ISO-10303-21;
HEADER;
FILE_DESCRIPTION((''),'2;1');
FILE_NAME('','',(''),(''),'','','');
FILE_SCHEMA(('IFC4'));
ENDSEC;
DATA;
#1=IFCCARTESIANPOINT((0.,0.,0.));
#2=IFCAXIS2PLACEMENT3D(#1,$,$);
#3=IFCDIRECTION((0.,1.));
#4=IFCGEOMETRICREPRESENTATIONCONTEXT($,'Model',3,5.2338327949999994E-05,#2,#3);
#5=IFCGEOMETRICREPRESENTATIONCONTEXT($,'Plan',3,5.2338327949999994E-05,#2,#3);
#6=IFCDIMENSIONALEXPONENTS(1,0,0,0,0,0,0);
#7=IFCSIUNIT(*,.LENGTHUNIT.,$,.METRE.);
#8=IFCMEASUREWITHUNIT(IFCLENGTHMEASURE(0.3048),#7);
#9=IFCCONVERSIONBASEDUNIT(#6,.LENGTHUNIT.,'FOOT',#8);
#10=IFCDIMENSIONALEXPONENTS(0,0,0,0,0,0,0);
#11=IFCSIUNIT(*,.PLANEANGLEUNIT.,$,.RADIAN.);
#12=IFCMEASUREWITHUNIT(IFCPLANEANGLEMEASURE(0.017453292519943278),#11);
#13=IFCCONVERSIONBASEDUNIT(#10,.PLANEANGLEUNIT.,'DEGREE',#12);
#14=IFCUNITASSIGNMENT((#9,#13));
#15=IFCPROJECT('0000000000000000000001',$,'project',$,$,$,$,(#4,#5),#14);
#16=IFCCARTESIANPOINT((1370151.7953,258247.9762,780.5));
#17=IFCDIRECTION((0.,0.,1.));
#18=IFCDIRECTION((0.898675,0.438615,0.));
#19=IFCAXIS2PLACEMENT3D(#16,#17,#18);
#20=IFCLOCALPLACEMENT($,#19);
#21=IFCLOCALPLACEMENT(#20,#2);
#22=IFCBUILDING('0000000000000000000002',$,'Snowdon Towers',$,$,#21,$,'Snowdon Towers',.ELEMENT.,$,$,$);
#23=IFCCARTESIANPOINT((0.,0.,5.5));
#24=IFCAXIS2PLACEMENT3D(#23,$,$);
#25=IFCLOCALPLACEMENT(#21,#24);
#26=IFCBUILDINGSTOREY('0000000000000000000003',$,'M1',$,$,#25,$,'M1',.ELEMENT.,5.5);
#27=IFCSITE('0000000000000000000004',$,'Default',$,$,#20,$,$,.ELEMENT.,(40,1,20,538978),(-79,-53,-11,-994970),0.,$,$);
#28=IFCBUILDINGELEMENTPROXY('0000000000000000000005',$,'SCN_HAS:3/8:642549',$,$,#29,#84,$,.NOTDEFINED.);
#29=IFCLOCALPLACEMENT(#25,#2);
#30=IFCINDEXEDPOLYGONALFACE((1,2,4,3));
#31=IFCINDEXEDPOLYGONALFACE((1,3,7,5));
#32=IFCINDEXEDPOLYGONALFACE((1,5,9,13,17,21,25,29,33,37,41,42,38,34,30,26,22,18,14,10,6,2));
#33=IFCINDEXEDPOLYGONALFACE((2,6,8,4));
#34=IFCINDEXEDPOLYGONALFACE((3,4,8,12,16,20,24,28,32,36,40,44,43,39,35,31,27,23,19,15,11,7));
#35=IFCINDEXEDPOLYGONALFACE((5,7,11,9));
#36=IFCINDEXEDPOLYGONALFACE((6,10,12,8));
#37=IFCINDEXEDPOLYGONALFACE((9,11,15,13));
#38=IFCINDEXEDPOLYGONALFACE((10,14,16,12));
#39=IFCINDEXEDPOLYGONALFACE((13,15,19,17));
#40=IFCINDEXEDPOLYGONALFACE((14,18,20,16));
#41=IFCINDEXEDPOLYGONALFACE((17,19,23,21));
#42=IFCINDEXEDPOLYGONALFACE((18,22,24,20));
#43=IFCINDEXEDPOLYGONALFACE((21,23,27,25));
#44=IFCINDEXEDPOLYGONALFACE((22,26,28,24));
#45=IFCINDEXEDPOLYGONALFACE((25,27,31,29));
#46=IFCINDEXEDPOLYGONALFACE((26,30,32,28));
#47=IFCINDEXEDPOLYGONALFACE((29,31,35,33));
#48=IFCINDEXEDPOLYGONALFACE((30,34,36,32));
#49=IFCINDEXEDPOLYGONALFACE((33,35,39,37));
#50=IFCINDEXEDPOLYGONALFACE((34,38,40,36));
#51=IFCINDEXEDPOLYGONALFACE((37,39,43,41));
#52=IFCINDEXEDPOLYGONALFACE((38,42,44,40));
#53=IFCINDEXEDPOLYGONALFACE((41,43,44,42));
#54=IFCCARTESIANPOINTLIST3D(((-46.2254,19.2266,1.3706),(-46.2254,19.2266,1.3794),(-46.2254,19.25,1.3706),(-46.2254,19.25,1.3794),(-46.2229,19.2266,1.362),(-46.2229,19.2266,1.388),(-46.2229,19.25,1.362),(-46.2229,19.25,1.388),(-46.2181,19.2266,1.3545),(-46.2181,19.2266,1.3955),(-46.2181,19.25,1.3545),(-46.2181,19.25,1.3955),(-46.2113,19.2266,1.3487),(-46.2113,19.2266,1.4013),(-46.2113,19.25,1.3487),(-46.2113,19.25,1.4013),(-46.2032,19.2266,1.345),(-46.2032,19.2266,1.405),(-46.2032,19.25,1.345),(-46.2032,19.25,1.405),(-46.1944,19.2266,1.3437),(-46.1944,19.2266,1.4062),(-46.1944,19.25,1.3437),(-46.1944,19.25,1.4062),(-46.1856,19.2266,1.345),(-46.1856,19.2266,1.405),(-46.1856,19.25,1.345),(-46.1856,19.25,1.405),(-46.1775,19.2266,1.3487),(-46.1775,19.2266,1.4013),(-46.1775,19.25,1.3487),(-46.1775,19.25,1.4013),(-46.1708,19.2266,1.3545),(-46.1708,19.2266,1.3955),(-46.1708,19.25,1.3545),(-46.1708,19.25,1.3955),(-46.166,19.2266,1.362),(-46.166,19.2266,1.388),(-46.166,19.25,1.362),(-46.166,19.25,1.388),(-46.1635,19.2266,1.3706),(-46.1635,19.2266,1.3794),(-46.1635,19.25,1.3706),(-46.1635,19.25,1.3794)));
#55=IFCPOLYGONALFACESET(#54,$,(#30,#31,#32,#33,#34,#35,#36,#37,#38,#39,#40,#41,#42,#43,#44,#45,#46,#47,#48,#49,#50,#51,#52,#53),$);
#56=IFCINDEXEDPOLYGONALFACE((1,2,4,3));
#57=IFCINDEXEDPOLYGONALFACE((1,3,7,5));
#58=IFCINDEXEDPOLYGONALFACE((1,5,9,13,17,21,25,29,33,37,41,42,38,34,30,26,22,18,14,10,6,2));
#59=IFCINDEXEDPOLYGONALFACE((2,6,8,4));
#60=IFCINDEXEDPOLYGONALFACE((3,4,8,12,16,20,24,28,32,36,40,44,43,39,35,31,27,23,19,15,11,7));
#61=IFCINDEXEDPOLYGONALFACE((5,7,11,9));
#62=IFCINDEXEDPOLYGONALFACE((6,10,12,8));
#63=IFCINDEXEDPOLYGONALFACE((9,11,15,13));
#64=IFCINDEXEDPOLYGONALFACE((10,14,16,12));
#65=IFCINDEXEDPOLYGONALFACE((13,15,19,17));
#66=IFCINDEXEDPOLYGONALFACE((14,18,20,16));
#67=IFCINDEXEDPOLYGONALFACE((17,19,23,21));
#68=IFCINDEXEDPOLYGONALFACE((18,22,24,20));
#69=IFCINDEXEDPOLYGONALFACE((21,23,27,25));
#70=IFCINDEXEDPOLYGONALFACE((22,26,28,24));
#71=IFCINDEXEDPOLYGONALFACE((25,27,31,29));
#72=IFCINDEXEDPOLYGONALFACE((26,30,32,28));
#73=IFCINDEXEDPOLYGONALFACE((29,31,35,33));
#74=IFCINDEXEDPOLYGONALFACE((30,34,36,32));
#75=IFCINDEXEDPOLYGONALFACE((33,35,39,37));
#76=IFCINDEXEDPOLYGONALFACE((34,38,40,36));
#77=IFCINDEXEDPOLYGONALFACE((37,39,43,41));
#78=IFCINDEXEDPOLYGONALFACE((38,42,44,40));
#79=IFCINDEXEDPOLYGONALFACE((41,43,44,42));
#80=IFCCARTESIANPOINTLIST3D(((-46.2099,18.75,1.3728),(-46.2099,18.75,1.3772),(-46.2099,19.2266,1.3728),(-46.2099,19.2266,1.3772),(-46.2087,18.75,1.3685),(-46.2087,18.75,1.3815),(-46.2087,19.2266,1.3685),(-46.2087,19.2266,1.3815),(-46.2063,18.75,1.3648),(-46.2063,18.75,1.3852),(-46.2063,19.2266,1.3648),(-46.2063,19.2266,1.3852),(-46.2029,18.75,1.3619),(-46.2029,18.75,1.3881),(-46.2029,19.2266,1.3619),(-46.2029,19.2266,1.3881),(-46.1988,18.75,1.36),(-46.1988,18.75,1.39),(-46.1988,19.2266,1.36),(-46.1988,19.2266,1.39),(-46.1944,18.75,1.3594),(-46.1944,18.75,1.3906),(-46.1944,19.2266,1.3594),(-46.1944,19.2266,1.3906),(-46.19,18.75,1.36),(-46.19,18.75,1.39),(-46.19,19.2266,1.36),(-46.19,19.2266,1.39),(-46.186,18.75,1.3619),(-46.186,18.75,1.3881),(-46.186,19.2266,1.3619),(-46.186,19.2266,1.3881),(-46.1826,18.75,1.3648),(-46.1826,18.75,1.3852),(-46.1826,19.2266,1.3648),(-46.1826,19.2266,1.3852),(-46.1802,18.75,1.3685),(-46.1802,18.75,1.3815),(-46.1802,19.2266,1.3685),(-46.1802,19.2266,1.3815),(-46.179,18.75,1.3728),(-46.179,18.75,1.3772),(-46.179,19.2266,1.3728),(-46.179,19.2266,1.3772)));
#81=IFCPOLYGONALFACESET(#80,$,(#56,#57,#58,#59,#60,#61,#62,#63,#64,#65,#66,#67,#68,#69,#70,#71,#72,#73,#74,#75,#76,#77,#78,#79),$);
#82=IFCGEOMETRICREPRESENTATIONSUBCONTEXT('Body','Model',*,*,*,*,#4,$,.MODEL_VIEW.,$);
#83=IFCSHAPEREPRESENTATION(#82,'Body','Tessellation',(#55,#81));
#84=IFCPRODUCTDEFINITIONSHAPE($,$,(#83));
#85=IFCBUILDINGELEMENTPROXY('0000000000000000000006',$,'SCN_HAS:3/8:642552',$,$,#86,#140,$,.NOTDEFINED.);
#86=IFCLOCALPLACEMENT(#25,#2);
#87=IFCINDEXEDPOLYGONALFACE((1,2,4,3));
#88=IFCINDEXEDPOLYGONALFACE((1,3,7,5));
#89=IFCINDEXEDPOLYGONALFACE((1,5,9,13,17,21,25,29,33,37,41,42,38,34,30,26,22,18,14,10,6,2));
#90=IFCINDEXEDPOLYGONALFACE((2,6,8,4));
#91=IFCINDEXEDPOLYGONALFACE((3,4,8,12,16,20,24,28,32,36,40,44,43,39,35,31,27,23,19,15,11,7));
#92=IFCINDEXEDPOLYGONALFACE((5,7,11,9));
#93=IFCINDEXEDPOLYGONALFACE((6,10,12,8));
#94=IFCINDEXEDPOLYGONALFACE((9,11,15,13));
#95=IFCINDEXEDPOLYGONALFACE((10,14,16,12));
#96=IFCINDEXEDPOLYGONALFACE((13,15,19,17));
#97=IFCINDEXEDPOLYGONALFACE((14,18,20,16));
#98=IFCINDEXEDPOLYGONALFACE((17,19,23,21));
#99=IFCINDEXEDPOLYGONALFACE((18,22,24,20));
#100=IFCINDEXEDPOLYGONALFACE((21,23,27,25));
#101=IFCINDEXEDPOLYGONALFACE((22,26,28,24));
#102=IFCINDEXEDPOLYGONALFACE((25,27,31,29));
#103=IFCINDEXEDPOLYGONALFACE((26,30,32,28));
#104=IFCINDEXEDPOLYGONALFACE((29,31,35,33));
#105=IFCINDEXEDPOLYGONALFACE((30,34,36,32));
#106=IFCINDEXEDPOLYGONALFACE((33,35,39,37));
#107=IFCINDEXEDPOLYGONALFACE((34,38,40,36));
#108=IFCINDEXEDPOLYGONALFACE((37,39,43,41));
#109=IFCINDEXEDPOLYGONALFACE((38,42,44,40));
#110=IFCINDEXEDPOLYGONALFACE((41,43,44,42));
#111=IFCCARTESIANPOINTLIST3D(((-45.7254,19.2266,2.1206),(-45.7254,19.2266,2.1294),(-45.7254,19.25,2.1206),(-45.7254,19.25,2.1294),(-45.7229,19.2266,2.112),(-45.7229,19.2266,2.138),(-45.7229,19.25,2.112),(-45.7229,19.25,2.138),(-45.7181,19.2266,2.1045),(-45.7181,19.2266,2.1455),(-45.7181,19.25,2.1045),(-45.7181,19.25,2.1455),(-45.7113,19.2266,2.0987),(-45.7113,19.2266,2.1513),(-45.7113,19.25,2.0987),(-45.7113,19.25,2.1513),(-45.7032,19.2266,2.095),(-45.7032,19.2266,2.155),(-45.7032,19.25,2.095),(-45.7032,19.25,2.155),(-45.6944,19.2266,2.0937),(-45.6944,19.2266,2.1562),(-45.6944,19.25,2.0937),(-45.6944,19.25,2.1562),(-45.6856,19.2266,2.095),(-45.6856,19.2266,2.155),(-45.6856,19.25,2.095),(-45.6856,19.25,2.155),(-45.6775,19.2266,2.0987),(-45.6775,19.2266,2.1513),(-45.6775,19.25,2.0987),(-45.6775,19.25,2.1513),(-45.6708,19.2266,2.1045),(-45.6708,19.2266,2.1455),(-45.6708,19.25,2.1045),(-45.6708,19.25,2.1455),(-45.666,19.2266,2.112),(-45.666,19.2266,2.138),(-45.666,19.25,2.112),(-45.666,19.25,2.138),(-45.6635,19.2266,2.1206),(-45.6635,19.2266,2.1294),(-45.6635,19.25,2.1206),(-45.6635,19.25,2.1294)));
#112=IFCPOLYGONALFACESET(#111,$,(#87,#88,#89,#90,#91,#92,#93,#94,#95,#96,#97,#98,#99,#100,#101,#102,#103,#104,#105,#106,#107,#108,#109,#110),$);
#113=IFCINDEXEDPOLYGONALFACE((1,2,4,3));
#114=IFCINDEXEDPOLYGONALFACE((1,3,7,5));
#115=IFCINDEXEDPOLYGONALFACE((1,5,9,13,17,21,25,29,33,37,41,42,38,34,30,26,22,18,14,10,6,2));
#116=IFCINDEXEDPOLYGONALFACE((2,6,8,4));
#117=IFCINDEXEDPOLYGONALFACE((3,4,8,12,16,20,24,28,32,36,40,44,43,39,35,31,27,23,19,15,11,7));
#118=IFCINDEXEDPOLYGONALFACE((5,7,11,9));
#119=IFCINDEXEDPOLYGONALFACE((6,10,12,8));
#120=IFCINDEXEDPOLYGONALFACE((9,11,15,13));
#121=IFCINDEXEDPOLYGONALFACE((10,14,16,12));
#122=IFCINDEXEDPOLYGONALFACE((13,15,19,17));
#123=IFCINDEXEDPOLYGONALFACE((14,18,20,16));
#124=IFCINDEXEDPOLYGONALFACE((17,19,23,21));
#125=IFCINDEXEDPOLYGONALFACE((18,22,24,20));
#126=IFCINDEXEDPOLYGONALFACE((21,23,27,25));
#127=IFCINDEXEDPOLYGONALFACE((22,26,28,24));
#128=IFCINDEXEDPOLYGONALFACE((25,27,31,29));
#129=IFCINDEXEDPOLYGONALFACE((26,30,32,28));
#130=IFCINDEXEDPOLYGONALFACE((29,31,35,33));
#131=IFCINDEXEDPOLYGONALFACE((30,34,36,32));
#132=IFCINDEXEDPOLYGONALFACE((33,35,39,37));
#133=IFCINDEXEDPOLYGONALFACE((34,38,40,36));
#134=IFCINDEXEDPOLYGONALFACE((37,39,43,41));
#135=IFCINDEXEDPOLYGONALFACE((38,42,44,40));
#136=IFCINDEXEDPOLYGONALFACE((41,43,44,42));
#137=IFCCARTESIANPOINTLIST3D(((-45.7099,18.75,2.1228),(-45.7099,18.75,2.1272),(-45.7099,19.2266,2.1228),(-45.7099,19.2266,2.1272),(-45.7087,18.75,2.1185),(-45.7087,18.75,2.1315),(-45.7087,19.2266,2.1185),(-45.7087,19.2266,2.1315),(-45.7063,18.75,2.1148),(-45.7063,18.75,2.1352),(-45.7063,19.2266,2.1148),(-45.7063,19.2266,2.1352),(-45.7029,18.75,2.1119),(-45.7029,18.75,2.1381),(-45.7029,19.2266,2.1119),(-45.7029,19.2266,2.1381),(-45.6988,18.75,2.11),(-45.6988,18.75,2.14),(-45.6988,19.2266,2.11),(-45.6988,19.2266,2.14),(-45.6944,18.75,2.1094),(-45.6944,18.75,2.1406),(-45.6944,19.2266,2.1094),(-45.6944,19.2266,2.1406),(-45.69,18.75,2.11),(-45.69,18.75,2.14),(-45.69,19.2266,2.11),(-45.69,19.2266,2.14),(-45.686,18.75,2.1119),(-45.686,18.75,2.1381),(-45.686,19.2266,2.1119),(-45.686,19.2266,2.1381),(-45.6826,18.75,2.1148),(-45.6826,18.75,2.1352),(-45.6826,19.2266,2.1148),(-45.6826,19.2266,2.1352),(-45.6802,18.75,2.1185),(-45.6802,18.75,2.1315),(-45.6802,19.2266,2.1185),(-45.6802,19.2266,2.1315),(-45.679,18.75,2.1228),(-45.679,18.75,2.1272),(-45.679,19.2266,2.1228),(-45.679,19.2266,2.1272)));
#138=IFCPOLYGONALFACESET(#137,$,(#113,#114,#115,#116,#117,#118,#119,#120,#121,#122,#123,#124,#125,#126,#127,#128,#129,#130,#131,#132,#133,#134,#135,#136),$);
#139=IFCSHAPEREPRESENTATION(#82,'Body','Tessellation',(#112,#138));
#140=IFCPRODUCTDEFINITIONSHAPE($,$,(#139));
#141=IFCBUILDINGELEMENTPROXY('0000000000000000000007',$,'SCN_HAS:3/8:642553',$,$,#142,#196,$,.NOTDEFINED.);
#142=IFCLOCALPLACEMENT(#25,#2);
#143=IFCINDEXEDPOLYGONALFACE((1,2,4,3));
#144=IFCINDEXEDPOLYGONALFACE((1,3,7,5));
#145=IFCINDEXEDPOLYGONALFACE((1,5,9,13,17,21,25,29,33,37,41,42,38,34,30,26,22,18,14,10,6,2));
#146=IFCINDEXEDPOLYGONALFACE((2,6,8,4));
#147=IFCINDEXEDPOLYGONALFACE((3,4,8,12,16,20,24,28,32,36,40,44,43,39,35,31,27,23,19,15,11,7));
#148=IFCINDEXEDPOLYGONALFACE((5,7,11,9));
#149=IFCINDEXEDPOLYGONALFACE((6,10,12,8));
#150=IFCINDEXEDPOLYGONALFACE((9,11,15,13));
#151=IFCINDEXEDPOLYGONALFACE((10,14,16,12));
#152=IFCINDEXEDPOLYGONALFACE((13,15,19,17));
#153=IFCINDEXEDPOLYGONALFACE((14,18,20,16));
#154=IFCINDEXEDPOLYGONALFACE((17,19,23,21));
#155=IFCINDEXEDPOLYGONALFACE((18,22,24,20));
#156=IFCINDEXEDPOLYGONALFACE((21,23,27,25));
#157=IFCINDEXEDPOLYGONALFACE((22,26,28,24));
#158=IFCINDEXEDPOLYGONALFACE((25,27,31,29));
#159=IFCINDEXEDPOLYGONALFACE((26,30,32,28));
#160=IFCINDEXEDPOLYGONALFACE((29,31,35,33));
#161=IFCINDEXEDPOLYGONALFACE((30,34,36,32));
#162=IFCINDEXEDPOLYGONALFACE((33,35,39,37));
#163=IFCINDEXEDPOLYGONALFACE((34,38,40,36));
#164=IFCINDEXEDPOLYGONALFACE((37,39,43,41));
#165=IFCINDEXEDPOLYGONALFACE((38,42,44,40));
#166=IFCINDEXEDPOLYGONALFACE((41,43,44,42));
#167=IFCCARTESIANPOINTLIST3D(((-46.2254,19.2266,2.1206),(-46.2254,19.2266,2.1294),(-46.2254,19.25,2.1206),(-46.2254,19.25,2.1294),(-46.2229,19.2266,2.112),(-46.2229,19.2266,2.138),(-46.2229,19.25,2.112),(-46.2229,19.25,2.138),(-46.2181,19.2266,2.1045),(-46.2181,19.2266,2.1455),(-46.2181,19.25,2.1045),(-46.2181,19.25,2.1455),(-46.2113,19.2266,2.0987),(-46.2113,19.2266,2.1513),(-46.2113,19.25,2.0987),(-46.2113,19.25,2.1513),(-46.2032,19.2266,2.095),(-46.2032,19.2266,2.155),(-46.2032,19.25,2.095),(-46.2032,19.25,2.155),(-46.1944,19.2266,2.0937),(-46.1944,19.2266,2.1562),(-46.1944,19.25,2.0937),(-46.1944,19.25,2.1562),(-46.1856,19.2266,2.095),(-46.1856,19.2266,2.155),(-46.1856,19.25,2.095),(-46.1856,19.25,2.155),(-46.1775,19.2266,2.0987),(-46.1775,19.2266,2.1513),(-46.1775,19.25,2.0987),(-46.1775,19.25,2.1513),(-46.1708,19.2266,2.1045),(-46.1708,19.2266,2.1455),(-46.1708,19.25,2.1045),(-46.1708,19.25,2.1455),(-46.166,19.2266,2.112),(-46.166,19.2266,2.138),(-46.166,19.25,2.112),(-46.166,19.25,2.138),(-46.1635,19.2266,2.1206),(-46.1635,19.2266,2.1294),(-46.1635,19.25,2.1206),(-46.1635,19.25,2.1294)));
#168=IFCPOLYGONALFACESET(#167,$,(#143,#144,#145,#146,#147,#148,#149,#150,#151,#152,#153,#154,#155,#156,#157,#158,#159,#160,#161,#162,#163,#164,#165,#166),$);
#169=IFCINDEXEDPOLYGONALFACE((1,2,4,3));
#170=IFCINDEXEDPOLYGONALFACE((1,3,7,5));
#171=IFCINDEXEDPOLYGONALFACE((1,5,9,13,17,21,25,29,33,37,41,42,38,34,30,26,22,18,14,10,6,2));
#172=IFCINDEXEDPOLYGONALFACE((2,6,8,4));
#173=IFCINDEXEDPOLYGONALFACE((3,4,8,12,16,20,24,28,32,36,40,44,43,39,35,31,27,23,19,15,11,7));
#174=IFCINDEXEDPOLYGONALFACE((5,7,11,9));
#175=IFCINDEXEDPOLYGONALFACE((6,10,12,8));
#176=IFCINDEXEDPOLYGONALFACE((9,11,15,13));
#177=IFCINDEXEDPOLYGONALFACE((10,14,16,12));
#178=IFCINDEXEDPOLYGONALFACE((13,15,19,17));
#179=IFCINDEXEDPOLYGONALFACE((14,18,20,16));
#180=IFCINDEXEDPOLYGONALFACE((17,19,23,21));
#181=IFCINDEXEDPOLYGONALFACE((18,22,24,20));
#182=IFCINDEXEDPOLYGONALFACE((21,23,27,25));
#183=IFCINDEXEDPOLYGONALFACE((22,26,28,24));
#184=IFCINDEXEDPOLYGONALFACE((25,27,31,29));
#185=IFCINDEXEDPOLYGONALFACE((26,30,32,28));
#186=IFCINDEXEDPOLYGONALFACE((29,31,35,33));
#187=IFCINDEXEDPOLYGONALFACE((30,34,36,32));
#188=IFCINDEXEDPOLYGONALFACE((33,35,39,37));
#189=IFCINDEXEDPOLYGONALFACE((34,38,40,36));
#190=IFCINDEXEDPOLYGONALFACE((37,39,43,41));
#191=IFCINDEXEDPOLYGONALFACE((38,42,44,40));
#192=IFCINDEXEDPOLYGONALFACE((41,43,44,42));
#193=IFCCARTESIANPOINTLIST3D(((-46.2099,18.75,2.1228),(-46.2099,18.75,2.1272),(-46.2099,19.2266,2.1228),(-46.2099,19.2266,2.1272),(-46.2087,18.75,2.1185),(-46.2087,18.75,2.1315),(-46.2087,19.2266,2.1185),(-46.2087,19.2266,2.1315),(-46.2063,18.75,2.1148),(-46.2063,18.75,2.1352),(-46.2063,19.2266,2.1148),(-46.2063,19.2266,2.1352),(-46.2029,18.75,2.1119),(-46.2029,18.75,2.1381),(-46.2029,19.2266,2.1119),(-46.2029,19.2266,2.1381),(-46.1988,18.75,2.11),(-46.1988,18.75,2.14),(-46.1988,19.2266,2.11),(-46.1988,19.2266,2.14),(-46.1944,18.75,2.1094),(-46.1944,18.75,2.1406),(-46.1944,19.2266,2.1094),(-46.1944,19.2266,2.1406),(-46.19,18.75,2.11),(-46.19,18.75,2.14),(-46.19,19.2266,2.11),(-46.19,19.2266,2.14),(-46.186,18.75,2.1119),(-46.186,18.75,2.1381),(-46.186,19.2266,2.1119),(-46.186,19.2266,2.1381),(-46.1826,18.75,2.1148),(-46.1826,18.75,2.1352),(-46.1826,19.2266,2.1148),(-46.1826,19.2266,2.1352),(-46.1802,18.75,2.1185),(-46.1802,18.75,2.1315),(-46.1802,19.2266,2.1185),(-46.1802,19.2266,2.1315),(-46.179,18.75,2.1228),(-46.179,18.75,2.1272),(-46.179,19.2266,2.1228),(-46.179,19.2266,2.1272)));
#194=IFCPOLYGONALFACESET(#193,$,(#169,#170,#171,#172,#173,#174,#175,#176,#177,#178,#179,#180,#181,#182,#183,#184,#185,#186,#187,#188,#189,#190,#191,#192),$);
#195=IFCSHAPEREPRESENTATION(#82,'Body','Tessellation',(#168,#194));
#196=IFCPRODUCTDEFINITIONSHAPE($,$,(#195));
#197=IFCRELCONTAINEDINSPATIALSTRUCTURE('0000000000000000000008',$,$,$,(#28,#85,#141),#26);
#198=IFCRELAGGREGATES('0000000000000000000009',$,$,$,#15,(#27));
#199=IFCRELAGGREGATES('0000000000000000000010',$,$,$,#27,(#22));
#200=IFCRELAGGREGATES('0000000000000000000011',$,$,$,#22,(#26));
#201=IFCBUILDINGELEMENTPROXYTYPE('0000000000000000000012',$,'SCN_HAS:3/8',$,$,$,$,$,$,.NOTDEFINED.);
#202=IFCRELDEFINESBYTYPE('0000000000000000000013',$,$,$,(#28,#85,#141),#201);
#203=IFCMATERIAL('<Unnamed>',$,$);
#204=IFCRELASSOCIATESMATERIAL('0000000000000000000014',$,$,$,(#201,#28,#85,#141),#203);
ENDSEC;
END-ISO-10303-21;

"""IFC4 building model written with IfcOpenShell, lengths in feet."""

from ifc_helpers import new_model, entity, si_unit, converted_unit, direction, frame, origin, place, context, subcontext, project, spatial, arc, indexed_curve, outline, extrude, source, transform, mapped, material, type_object, type_shapes, element, save


model = new_model("IFC4")

# Units and contexts
model_context = context("Model", 3, precision=5.2338327949999994e-05, world=origin(), true_north=direction((0.0, 1.0)))
plan_context = context("Plan", 3, precision=5.2338327949999994e-05, world=origin(), true_north=direction((0.0, 1.0)))
body_context = subcontext(model_context, "Body", "Model", "MODEL_VIEW")
ifc_project = project(units=[converted_unit("LENGTHUNIT", "FOOT", entity("IfcLengthMeasure", 0.3048), si_unit("LENGTHUNIT", "METRE"), dimensions=[1, 0, 0, 0, 0, 0, 0]), converted_unit("PLANEANGLEUNIT", "DEGREE", entity("IfcPlaneAngleMeasure", 0.017453292519943278), si_unit("PLANEANGLEUNIT", "RADIAN"), dimensions=[0, 0, 0, 0, 0, 0, 0])], contexts=[model_context, plan_context])

# Site, building, storey
site_placement = place(None, frame((1370151.7953, 258247.9762, 780.5), z_axis=(0.0, 0.0, 1.0), x_axis=(0.898675, 0.438615, 0.0)))
site = spatial("IfcSite", under=ifc_project, at=site_placement, Name="Default", CompositionType="ELEMENT", RefLatitude=(40, 1, 20, 538978), RefLongitude=(-79, -53, -11, -994970), RefElevation=0.0)
building_placement = place(site_placement, origin())
building = spatial("IfcBuilding", under=site, at=building_placement, Name="Snowdon Towers", LongName="Snowdon Towers", CompositionType="ELEMENT")
storey_placement = place(building_placement, frame((0.0, 0.0, 5.5)))
storey = spatial("IfcBuildingStorey", under=building, at=storey_placement, Name="M1", LongName="M1", CompositionType="ELEMENT", Elevation=5.5)

# Building element proxies
ifc_material_1 = material(Name="<Unnamed>")
building_element_proxy_type = type_object("IfcBuildingElementProxyType", Name="SCN_HAS:3/8", PredefinedType="NOTDEFINED", material=ifc_material_1)
shared_shape_1 = source(origin(), body_context, "Body", "SweptSolid", [
    extrude(outline(indexed_curve([(-0.0312, 0.0), (0.0, -0.0313), (0.0312, 0.0), (0.0, 0.0312)], segments=[arc(1, 2, 3), arc(3, 4, 1)], self_intersect=False)), frame((0.0, 0.0, -0.5), z_axis=(0.0, 0.0, 1.0), x_axis=(0.0, -1.0, 0.0)), (0.0, 0.0, 1.0), 0.0234),
    extrude(outline(indexed_curve([(-0.0156, 0.0), (0.0, -0.0156), (0.0156, 0.0), (0.0, 0.0156)], segments=[arc(1, 2, 3), arc(3, 4, 1)], self_intersect=False)), frame((0.0, 0.0, -0.4766), z_axis=(0.0, 0.0, 1.0), x_axis=(0.0, -1.0, 0.0)), (0.0, 0.0, 1.0), 0.4766),
])
type_shapes(building_element_proxy_type, [shared_shape_1])
for number, where, z_axis, x_axis, name in (
    (1, (-46.1944, 18.75, 1.375), (0.0, -1.0, 0.0), (1.0, 0.0, 0.0), "SCN_HAS:3/8:642549"),
    (2, (-45.6944, 18.75, 2.125), (0.0, -1.0, 0.0), (1.0, 0.0, 0.0), "SCN_HAS:3/8:642552"),
    (3, (-46.1944, 18.75, 2.125), (0.0, -1.0, 0.0), (1.0, 0.0, 0.0), "SCN_HAS:3/8:642553"),
):
    element("IfcBuildingElementProxy", number, at=place(storey_placement, frame(where, z_axis=z_axis, x_axis=x_axis)), inside=storey, type_object=building_element_proxy_type, material=ifc_material_1, Name=name, PredefinedType="NOTDEFINED", context=body_context, shape_type="MappedRepresentation", body=[
        mapped(shared_shape_1, transform((0.0, 0.0, 0.0), scale=1.0)),
    ])

save(model, "model.ifc")
